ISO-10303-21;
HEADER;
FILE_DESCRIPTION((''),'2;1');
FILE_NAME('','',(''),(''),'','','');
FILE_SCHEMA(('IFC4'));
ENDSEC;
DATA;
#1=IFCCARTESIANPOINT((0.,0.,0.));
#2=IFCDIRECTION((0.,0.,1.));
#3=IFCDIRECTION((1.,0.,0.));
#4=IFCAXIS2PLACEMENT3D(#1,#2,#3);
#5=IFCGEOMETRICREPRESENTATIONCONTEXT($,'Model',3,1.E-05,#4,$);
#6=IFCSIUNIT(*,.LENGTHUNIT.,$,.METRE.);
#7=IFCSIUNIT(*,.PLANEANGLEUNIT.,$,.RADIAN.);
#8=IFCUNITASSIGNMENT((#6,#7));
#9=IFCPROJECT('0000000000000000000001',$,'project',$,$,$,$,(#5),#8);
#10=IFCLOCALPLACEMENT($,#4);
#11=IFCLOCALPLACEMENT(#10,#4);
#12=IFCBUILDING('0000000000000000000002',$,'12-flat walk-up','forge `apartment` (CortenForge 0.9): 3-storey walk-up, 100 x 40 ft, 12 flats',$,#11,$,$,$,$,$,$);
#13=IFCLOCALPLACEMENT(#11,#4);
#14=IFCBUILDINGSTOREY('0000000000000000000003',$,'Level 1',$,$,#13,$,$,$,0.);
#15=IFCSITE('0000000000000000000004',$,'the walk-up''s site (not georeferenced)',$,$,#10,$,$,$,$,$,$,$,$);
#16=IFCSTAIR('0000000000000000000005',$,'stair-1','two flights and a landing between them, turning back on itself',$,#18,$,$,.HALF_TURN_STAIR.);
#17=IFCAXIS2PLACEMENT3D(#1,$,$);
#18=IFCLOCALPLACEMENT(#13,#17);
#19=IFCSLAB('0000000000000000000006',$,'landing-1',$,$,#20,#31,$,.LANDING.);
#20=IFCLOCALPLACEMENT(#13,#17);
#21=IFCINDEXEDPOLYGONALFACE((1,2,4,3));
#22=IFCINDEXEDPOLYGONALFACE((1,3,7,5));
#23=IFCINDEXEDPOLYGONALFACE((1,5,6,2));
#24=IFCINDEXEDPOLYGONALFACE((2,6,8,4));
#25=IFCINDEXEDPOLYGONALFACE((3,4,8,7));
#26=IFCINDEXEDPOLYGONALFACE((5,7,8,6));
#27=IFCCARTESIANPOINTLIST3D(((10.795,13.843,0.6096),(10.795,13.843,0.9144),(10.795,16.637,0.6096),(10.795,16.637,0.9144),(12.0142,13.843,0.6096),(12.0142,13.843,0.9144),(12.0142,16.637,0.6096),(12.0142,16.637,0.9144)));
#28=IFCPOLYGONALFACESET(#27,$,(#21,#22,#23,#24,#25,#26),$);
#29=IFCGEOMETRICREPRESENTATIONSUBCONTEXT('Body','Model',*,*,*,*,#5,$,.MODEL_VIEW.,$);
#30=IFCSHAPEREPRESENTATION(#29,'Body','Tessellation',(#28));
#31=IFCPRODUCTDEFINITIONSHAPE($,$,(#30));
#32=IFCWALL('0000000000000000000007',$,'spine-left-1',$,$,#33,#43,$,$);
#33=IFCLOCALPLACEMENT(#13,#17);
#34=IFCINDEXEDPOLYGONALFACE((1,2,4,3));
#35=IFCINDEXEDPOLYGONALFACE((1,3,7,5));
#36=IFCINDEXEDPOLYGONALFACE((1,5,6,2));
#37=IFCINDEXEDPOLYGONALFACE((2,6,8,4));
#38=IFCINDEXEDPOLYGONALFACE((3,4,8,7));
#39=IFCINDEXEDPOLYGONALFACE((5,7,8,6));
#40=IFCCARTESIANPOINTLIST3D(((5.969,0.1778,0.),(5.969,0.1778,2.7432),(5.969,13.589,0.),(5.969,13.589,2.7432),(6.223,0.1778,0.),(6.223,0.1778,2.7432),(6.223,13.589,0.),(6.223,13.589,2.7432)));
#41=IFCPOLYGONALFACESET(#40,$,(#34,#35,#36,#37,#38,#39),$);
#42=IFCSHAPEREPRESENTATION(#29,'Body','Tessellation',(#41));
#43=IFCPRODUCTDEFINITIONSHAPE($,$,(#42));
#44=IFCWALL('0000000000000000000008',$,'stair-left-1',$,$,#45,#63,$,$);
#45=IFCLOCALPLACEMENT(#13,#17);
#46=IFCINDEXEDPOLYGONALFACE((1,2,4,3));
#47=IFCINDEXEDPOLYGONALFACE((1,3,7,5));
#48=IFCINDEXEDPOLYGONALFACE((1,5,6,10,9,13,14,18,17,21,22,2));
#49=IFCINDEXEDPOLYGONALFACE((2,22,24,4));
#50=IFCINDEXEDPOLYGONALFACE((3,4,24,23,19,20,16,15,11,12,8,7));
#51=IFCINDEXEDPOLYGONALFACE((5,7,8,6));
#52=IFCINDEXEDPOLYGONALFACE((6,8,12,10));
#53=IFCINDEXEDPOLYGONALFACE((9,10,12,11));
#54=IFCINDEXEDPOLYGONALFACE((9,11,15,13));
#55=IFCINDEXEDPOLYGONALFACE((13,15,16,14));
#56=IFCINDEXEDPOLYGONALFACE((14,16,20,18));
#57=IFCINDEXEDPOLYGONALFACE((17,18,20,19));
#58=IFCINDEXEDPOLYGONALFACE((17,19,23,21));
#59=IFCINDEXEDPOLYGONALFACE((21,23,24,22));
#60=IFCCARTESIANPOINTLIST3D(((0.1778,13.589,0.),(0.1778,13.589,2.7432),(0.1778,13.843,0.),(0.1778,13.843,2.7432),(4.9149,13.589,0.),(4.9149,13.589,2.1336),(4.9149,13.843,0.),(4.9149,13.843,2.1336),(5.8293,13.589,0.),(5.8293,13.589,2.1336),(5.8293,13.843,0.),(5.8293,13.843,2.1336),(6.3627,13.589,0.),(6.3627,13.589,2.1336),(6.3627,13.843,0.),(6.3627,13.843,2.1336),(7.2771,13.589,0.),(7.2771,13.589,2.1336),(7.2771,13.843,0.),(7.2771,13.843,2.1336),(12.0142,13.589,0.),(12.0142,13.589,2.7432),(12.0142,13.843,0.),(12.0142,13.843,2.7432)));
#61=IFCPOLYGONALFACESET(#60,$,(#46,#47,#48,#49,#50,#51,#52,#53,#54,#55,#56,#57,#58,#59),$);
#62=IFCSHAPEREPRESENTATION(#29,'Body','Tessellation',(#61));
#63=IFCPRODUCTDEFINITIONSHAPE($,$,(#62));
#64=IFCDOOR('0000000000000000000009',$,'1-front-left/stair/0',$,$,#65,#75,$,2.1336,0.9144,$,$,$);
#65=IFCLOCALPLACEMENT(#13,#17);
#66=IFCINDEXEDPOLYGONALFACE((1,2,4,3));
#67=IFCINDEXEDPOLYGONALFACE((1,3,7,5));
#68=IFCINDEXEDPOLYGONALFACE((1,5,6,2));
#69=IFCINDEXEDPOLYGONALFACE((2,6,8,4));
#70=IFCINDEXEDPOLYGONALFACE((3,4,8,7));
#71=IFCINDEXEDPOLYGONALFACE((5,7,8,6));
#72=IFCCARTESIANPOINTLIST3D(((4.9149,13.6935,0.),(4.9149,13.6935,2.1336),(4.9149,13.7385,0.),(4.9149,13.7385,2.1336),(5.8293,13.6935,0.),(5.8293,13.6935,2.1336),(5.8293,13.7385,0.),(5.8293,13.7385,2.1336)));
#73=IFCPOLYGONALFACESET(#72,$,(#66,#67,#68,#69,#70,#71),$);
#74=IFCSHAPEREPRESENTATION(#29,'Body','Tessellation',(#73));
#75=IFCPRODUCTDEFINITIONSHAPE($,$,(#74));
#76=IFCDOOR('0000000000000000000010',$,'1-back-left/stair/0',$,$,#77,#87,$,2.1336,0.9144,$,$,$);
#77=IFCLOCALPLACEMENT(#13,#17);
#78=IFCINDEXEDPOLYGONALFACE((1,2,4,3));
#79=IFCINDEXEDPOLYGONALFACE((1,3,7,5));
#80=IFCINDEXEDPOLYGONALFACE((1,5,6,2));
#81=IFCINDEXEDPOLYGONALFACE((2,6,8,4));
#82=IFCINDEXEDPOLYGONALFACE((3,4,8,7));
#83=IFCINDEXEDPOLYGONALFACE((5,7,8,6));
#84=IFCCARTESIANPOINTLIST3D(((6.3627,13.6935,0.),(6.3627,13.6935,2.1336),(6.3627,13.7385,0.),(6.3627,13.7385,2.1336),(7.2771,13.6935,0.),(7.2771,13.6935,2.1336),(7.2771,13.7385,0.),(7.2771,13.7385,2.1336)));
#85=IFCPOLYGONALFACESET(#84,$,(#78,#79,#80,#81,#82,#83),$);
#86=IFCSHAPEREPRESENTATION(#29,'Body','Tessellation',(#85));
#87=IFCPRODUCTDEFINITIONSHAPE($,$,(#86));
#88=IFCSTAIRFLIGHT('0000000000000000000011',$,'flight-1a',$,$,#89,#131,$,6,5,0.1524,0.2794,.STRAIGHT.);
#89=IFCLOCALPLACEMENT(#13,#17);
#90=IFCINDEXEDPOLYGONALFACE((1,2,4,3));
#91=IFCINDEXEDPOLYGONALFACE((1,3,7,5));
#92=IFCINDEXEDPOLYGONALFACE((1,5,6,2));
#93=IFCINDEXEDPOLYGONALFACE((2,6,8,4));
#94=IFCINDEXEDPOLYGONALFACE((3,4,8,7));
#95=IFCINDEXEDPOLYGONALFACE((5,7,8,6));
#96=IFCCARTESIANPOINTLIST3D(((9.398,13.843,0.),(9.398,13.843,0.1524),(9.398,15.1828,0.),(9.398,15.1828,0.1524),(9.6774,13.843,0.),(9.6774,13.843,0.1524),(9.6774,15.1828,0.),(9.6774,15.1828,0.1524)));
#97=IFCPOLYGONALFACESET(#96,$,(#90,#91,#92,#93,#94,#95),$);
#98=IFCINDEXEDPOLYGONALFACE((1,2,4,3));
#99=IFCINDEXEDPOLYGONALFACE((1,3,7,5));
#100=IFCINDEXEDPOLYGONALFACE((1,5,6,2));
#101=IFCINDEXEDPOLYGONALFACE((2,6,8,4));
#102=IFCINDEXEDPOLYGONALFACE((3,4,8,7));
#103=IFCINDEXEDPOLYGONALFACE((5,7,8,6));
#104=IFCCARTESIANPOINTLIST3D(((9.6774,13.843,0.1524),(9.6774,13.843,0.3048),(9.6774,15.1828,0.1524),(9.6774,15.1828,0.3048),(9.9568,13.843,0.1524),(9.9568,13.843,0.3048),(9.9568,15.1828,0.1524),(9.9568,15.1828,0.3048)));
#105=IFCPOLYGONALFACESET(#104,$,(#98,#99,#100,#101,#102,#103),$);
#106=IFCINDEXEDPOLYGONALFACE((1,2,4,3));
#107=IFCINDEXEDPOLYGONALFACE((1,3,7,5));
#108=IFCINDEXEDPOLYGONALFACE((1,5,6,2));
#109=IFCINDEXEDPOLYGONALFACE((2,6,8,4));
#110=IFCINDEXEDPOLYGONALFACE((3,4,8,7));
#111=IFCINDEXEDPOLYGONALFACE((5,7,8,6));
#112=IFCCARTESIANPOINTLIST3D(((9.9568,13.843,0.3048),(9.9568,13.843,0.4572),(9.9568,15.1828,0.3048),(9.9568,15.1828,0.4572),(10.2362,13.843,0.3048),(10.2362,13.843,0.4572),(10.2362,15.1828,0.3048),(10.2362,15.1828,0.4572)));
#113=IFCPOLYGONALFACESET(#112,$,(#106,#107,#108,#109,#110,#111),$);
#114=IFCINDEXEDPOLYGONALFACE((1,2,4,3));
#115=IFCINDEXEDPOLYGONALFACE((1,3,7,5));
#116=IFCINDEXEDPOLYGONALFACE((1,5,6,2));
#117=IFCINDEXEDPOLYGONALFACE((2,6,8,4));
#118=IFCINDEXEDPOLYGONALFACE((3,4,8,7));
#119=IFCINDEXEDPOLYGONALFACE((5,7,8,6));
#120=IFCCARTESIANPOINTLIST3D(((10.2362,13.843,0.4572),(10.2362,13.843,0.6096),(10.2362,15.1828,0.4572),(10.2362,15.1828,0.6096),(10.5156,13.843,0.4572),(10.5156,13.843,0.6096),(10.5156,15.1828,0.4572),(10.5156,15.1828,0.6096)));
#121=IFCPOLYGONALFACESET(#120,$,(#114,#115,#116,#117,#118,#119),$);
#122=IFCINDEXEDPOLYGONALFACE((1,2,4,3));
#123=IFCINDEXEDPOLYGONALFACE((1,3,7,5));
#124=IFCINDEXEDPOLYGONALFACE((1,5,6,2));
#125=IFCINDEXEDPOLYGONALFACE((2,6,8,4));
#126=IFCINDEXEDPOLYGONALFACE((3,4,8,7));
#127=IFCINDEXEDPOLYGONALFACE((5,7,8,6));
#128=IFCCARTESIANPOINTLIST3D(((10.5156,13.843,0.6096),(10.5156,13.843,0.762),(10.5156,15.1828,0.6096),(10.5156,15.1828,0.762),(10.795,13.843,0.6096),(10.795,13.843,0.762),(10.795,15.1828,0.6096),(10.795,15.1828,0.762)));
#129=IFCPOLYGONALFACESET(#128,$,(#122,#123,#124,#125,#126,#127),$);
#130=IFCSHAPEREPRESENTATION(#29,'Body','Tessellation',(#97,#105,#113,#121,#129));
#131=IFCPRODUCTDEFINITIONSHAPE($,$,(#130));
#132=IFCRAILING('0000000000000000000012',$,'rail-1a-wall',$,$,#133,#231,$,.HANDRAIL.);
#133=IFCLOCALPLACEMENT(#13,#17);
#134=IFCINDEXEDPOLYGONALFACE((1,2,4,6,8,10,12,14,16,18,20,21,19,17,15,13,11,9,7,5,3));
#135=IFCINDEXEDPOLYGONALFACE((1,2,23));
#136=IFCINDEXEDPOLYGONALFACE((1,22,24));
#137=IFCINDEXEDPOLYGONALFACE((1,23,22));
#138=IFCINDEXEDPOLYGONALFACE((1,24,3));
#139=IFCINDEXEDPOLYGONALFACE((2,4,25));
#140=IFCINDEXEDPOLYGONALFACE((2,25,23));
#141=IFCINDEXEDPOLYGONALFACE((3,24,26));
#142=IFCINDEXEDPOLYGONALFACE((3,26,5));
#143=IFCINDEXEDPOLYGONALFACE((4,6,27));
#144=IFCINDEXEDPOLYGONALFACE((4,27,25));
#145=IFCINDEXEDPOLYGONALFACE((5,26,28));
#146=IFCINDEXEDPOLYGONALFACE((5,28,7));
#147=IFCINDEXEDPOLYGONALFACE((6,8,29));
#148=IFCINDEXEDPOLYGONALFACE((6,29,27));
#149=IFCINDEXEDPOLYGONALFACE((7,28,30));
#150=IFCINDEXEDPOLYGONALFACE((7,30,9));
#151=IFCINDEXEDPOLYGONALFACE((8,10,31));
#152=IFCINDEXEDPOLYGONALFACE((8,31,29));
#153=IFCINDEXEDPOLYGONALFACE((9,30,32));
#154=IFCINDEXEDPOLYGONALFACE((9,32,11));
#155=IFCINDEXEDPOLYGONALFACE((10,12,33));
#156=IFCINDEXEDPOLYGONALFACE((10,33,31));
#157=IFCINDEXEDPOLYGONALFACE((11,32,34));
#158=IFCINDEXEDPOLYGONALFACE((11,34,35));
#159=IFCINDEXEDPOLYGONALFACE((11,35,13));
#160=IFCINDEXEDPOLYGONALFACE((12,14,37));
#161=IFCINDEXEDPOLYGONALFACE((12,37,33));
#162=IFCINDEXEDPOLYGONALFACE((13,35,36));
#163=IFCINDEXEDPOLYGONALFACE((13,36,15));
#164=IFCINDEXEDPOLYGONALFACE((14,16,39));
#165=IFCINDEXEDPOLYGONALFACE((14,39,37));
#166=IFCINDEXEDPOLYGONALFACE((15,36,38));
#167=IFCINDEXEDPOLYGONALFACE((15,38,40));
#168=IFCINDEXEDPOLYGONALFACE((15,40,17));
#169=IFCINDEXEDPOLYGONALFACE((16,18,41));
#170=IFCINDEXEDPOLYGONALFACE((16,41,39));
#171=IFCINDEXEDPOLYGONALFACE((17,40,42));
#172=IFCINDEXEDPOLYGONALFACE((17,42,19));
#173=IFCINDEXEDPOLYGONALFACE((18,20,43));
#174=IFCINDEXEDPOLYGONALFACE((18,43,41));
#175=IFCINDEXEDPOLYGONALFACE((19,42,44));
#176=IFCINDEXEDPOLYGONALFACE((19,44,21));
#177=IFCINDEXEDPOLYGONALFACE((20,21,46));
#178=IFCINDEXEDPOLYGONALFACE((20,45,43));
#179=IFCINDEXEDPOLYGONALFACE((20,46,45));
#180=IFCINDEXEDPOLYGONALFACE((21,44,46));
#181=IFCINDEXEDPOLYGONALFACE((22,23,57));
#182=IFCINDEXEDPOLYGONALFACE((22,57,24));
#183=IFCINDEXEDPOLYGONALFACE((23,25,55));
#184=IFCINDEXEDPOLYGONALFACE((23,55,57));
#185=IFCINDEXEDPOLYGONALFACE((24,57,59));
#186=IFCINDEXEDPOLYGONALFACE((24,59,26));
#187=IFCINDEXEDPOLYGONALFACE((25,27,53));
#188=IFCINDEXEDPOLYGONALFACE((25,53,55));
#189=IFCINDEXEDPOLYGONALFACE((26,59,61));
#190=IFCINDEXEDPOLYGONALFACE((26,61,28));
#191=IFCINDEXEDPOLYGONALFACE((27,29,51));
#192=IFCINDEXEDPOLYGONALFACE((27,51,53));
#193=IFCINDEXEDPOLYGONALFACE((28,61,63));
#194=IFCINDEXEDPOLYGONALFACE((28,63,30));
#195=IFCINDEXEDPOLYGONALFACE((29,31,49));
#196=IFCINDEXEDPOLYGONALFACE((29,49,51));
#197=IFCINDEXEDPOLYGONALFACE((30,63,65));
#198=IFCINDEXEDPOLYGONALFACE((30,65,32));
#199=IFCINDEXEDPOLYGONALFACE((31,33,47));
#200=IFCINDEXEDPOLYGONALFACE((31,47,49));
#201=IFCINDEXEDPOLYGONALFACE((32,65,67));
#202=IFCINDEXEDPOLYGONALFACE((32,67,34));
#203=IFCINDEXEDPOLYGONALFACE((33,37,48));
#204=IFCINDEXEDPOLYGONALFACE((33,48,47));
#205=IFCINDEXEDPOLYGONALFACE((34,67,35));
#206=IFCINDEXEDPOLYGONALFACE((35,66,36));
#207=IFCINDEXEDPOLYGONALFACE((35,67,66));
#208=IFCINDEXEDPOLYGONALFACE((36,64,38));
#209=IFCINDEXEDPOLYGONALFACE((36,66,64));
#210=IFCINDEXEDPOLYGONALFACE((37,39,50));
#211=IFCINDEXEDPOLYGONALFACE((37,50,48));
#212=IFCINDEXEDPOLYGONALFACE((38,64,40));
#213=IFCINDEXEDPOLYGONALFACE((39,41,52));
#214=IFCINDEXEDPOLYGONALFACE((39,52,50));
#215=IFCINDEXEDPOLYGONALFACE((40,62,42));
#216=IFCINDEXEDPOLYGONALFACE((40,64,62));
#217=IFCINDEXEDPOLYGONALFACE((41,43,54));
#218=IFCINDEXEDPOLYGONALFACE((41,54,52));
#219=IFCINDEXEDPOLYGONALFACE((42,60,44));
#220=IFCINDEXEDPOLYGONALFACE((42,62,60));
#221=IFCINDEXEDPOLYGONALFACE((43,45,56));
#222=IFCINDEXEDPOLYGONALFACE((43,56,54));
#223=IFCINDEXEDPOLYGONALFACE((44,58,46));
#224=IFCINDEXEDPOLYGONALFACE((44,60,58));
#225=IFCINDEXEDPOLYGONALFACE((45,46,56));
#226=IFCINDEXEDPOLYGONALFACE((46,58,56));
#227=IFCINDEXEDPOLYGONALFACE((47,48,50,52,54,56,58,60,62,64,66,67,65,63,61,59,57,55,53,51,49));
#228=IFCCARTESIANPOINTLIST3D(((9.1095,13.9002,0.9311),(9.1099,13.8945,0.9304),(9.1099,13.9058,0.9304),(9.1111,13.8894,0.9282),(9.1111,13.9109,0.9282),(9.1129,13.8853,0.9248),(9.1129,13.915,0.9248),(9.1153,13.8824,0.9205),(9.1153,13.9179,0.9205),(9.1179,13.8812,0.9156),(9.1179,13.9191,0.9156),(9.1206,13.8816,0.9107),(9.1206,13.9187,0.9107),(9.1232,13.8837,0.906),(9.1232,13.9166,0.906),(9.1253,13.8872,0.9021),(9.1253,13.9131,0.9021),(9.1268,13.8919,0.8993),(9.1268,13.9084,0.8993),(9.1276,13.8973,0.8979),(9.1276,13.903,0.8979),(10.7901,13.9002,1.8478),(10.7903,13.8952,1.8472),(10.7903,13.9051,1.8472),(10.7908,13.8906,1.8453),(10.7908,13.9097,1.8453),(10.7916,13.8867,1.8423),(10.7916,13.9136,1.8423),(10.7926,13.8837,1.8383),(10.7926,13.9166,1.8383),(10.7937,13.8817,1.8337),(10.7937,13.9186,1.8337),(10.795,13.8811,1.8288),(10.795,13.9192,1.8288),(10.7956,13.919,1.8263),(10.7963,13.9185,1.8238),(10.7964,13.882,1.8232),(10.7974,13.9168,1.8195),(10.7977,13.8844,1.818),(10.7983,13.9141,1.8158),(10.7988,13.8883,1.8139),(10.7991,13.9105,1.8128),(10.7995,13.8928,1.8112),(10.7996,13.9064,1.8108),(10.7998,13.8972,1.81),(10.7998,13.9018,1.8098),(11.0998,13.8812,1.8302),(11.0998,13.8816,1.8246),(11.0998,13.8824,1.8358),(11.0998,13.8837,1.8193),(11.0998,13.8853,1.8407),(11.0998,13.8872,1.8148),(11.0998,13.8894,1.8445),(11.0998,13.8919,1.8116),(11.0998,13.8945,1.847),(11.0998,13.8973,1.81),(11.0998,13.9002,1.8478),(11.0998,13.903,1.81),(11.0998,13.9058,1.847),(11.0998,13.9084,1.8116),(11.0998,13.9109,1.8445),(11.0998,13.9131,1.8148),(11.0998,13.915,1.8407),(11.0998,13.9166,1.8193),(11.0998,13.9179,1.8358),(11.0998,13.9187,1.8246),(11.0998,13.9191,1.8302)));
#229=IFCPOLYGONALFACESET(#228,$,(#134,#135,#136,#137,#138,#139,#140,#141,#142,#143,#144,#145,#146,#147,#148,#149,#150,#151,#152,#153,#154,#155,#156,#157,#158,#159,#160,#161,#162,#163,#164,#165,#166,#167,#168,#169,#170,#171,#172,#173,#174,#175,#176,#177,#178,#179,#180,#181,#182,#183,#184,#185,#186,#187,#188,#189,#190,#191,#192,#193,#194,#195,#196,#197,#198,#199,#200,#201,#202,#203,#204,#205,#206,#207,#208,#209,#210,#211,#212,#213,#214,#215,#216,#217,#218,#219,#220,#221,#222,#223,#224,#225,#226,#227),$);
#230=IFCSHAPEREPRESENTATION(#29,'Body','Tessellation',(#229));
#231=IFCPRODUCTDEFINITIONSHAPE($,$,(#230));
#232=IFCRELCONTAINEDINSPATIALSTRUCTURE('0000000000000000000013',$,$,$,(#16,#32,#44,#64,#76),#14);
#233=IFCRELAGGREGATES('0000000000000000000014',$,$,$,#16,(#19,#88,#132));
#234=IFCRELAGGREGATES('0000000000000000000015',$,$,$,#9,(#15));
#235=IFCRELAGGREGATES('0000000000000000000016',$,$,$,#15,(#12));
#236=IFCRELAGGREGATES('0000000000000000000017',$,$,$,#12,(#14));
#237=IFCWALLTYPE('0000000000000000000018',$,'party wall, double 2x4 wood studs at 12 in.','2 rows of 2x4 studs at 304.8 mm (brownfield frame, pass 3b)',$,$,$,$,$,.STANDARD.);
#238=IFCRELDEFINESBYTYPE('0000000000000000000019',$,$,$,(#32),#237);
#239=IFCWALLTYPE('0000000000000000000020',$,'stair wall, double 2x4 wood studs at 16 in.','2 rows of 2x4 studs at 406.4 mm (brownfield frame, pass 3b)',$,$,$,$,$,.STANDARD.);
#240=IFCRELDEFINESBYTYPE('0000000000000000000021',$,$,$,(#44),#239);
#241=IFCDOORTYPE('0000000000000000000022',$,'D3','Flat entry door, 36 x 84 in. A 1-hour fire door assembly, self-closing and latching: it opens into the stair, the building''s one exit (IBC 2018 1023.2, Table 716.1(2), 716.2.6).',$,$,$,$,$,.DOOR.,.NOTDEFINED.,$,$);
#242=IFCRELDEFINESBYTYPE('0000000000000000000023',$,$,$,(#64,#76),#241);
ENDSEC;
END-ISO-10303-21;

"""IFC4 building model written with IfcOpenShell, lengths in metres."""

from ifc_helpers import new_model, entity, si_unit, frame, frame_2d, origin, origin_with_axes, place, context, subcontext, project, spatial, rectangle, extrude, type_object, element, fill, aggregate, save


model = new_model("IFC4")

# Units and contexts
model_context = context("Model", 3, precision=1e-05, world=origin_with_axes())
body_context = subcontext(model_context, "Body", "Model", "MODEL_VIEW")
ifc_project = project(units=[si_unit("LENGTHUNIT", "METRE"), si_unit("PLANEANGLEUNIT", "RADIAN")], contexts=[model_context])

# Site, building, storey
site_placement = place(None, origin_with_axes())
site = spatial("IfcSite", under=ifc_project, at=site_placement, Name="the walk-up's site (not georeferenced)")
building_placement = place(site_placement, origin_with_axes())
building = spatial("IfcBuilding", under=site, at=building_placement, Name="12-flat walk-up", Description="forge `apartment` (CortenForge 0.9): 3-storey walk-up, 100 x 40 ft, 12 flats")
storey_placement = place(building_placement, origin_with_axes())
storey = spatial("IfcBuildingStorey", under=building, at=storey_placement, Name="Level 1", Elevation=0.0)

# Stair, slab
stair_placement = place(storey_placement, origin_with_axes())
stair = element("IfcStair", 1, at=stair_placement, inside=storey, Name="stair-1", Description="two flights and a landing between them, turning back on itself", PredefinedType="HALF_TURN_STAIR")
slab_placement = place(stair_placement, frame((10.795, 13.843, 0.6096), z_axis=(0.0, 0.0, 1.0), x_axis=(1.0, 0.0, 0.0)))
slab = element("IfcSlab", 2, at=slab_placement, Name="landing-1", PredefinedType="LANDING", context=body_context, shape_type="SweptSolid", body=[
    extrude(rectangle(XDim=1.2192, YDim=2.794, at=frame_2d((0.6096, 1.397))), origin(), (0.0, 0.0, 1.0), 0.3048),
])

# Wall
wall_type_1 = type_object("IfcWallType", Name="party wall, double 2x4 wood studs at 12 in.", Description="2 rows of 2x4 studs at 304.8 mm (brownfield frame, pass 3b)", PredefinedType="STANDARD")
wall_1_placement = place(storey_placement, frame((5.969, 0.1778, 0.0), z_axis=(0.0, 0.0, 1.0), x_axis=(1.0, 0.0, 0.0)))
element("IfcWall", 3, at=wall_1_placement, inside=storey, type_object=wall_type_1, Name="spine-left-1", context=body_context, shape_type="SweptSolid", body=[
    extrude(rectangle(XDim=0.254, YDim=13.4112, at=frame_2d((0.127, 6.7056))), origin(), (0.0, 0.0, 1.0), 2.7432),
])

# Wall, openings, doors
wall_type_2 = type_object("IfcWallType", Name="stair wall, double 2x4 wood studs at 16 in.", Description="2 rows of 2x4 studs at 406.4 mm (brownfield frame, pass 3b)", PredefinedType="STANDARD")
wall_2_placement = place(storey_placement, frame((0.1778, 13.589, 0.0), z_axis=(0.0, 0.0, 1.0), x_axis=(1.0, 0.0, 0.0)))
wall_2 = element("IfcWall", 4, at=wall_2_placement, inside=storey, type_object=wall_type_2, Name="stair-left-1", context=body_context, shape_type="SweptSolid", body=[
    extrude(rectangle(XDim=11.8364, YDim=0.254, at=frame_2d((5.9182, 0.127))), origin(), (0.0, 0.0, 1.0), 2.7432),
])
opening_1_placement = place(wall_2_placement, frame((4.7371, 0.0, 0.0), z_axis=(0.0, 0.0, 1.0), x_axis=(1.0, 0.0, 0.0)))
opening_1 = element("IfcOpeningElement", 5, at=opening_1_placement, cuts=wall_2, PredefinedType="OPENING", context=body_context, shape_type="SweptSolid", body=[
    extrude(rectangle(XDim=0.9144, YDim=0.254, at=frame_2d((0.4572, 0.127))), origin(), (0.0, 0.0, 1.0), 2.1336),
])
opening_2_placement = place(wall_2_placement, frame((6.1849, 0.0, 0.0), z_axis=(0.0, 0.0, 1.0), x_axis=(1.0, 0.0, 0.0)))
opening_2 = element("IfcOpeningElement", 6, at=opening_2_placement, cuts=wall_2, PredefinedType="OPENING", context=body_context, shape_type="SweptSolid", body=[
    extrude(rectangle(XDim=0.9144, YDim=0.254, at=frame_2d((0.4572, 0.127))), origin(), (0.0, 0.0, 1.0), 2.1336),
])
door_type = type_object("IfcDoorType", Name="D3", Description="Flat entry door, 36 x 84 in. A 1-hour fire door assembly, self-closing and latching: it opens into the stair, the building's one exit (IBC 2018 1023.2, Table 716.1(2), 716.2.6).", OperationType="NOTDEFINED", PredefinedType="DOOR")
door_1_placement = place(opening_1_placement, frame((0.0, 0.1045, 0.0), z_axis=(0.0, 0.0, 1.0), x_axis=(1.0, 0.0, 0.0)))
door_1 = element("IfcDoor", 7, at=door_1_placement, inside=storey, type_object=door_type, Name="1-front-left/stair/0", OverallHeight=2.1336, OverallWidth=0.9144, context=body_context, shape_type="SweptSolid", body=[
    extrude(rectangle(XDim=0.9144, YDim=0.045, at=frame_2d((0.4572, 0.0225))), origin(), (0.0, 0.0, 1.0), 2.1336),
])
fill(opening_1, door_1)
door_2_placement = place(opening_2_placement, frame((0.0, 0.1045, 0.0), z_axis=(0.0, 0.0, 1.0), x_axis=(1.0, 0.0, 0.0)))
door_2 = element("IfcDoor", 8, at=door_2_placement, inside=storey, type_object=door_type, Name="1-back-left/stair/0", OverallHeight=2.1336, OverallWidth=0.9144, context=body_context, shape_type="SweptSolid", body=[
    extrude(rectangle(XDim=0.9144, YDim=0.045, at=frame_2d((0.4572, 0.0225))), origin(), (0.0, 0.0, 1.0), 2.1336),
])
fill(opening_2, door_2)

# Stair flight
stair_flight_placement = place(stair_placement, frame((9.398, 13.843, 0.0), z_axis=(0.0, 0.0, 1.0), x_axis=(1.0, 0.0, 0.0)))
stair_flight = element("IfcStairFlight", 9, at=stair_flight_placement, Name="flight-1a", NumberOfRisers=6, NumberOfTreads=5, PredefinedType="STRAIGHT", RiserHeight=0.1524, TreadLength=0.2794, context=body_context, shape_type="SweptSolid", body=[
    extrude(rectangle(XDim=0.2794, YDim=1.3399, at=frame_2d((0.1397, 0.6699))), origin(), (0.0, 0.0, 1.0), 0.1524),
    extrude(rectangle(XDim=0.2794, YDim=1.3399, at=frame_2d((0.1397, 0.6699))), frame((0.2794, 0.0, 0.1524)), (0.0, 0.0, 1.0), 0.1524),
    extrude(rectangle(XDim=0.2794, YDim=1.3399, at=frame_2d((0.1397, 0.6699))), frame((0.5588, 0.0, 0.3048)), (0.0, 0.0, 1.0), 0.1524),
    extrude(rectangle(XDim=0.2794, YDim=1.3399, at=frame_2d((0.1397, 0.6699))), frame((0.8382, 0.0, 0.4572)), (0.0, 0.0, 1.0), 0.1524),
    extrude(rectangle(XDim=0.2794, YDim=1.3399, at=frame_2d((0.1397, 0.6699))), frame((1.1176, 0.0, 0.6096)), (0.0, 0.0, 1.0), 0.1524),
])

# Railing
railing_placement = place(stair_placement, frame((9.1186, 13.9002, 0.9144), z_axis=(0.0, 0.0, 1.0), x_axis=(1.0, 0.0, 0.0)))
railing = element("IfcRailing", 10, at=railing_placement, Name="rail-1a-wall", PredefinedType="HANDRAIL", context=body_context, shape_type="AdvancedSweptSolid", body=[
    entity("IfcSweptDiskSolid", entity("IfcPolyline", [entity("IfcCartesianPoint", [0.0, 0.0, 0.0]), entity("IfcCartesianPoint", [1.6764, 0.0, 0.9144]), entity("IfcCartesianPoint", [1.9812, 0.0, 0.9144])]), 0.0191),
])
aggregate(stair, [slab, stair_flight, railing])

save(model, "model.ifc")
